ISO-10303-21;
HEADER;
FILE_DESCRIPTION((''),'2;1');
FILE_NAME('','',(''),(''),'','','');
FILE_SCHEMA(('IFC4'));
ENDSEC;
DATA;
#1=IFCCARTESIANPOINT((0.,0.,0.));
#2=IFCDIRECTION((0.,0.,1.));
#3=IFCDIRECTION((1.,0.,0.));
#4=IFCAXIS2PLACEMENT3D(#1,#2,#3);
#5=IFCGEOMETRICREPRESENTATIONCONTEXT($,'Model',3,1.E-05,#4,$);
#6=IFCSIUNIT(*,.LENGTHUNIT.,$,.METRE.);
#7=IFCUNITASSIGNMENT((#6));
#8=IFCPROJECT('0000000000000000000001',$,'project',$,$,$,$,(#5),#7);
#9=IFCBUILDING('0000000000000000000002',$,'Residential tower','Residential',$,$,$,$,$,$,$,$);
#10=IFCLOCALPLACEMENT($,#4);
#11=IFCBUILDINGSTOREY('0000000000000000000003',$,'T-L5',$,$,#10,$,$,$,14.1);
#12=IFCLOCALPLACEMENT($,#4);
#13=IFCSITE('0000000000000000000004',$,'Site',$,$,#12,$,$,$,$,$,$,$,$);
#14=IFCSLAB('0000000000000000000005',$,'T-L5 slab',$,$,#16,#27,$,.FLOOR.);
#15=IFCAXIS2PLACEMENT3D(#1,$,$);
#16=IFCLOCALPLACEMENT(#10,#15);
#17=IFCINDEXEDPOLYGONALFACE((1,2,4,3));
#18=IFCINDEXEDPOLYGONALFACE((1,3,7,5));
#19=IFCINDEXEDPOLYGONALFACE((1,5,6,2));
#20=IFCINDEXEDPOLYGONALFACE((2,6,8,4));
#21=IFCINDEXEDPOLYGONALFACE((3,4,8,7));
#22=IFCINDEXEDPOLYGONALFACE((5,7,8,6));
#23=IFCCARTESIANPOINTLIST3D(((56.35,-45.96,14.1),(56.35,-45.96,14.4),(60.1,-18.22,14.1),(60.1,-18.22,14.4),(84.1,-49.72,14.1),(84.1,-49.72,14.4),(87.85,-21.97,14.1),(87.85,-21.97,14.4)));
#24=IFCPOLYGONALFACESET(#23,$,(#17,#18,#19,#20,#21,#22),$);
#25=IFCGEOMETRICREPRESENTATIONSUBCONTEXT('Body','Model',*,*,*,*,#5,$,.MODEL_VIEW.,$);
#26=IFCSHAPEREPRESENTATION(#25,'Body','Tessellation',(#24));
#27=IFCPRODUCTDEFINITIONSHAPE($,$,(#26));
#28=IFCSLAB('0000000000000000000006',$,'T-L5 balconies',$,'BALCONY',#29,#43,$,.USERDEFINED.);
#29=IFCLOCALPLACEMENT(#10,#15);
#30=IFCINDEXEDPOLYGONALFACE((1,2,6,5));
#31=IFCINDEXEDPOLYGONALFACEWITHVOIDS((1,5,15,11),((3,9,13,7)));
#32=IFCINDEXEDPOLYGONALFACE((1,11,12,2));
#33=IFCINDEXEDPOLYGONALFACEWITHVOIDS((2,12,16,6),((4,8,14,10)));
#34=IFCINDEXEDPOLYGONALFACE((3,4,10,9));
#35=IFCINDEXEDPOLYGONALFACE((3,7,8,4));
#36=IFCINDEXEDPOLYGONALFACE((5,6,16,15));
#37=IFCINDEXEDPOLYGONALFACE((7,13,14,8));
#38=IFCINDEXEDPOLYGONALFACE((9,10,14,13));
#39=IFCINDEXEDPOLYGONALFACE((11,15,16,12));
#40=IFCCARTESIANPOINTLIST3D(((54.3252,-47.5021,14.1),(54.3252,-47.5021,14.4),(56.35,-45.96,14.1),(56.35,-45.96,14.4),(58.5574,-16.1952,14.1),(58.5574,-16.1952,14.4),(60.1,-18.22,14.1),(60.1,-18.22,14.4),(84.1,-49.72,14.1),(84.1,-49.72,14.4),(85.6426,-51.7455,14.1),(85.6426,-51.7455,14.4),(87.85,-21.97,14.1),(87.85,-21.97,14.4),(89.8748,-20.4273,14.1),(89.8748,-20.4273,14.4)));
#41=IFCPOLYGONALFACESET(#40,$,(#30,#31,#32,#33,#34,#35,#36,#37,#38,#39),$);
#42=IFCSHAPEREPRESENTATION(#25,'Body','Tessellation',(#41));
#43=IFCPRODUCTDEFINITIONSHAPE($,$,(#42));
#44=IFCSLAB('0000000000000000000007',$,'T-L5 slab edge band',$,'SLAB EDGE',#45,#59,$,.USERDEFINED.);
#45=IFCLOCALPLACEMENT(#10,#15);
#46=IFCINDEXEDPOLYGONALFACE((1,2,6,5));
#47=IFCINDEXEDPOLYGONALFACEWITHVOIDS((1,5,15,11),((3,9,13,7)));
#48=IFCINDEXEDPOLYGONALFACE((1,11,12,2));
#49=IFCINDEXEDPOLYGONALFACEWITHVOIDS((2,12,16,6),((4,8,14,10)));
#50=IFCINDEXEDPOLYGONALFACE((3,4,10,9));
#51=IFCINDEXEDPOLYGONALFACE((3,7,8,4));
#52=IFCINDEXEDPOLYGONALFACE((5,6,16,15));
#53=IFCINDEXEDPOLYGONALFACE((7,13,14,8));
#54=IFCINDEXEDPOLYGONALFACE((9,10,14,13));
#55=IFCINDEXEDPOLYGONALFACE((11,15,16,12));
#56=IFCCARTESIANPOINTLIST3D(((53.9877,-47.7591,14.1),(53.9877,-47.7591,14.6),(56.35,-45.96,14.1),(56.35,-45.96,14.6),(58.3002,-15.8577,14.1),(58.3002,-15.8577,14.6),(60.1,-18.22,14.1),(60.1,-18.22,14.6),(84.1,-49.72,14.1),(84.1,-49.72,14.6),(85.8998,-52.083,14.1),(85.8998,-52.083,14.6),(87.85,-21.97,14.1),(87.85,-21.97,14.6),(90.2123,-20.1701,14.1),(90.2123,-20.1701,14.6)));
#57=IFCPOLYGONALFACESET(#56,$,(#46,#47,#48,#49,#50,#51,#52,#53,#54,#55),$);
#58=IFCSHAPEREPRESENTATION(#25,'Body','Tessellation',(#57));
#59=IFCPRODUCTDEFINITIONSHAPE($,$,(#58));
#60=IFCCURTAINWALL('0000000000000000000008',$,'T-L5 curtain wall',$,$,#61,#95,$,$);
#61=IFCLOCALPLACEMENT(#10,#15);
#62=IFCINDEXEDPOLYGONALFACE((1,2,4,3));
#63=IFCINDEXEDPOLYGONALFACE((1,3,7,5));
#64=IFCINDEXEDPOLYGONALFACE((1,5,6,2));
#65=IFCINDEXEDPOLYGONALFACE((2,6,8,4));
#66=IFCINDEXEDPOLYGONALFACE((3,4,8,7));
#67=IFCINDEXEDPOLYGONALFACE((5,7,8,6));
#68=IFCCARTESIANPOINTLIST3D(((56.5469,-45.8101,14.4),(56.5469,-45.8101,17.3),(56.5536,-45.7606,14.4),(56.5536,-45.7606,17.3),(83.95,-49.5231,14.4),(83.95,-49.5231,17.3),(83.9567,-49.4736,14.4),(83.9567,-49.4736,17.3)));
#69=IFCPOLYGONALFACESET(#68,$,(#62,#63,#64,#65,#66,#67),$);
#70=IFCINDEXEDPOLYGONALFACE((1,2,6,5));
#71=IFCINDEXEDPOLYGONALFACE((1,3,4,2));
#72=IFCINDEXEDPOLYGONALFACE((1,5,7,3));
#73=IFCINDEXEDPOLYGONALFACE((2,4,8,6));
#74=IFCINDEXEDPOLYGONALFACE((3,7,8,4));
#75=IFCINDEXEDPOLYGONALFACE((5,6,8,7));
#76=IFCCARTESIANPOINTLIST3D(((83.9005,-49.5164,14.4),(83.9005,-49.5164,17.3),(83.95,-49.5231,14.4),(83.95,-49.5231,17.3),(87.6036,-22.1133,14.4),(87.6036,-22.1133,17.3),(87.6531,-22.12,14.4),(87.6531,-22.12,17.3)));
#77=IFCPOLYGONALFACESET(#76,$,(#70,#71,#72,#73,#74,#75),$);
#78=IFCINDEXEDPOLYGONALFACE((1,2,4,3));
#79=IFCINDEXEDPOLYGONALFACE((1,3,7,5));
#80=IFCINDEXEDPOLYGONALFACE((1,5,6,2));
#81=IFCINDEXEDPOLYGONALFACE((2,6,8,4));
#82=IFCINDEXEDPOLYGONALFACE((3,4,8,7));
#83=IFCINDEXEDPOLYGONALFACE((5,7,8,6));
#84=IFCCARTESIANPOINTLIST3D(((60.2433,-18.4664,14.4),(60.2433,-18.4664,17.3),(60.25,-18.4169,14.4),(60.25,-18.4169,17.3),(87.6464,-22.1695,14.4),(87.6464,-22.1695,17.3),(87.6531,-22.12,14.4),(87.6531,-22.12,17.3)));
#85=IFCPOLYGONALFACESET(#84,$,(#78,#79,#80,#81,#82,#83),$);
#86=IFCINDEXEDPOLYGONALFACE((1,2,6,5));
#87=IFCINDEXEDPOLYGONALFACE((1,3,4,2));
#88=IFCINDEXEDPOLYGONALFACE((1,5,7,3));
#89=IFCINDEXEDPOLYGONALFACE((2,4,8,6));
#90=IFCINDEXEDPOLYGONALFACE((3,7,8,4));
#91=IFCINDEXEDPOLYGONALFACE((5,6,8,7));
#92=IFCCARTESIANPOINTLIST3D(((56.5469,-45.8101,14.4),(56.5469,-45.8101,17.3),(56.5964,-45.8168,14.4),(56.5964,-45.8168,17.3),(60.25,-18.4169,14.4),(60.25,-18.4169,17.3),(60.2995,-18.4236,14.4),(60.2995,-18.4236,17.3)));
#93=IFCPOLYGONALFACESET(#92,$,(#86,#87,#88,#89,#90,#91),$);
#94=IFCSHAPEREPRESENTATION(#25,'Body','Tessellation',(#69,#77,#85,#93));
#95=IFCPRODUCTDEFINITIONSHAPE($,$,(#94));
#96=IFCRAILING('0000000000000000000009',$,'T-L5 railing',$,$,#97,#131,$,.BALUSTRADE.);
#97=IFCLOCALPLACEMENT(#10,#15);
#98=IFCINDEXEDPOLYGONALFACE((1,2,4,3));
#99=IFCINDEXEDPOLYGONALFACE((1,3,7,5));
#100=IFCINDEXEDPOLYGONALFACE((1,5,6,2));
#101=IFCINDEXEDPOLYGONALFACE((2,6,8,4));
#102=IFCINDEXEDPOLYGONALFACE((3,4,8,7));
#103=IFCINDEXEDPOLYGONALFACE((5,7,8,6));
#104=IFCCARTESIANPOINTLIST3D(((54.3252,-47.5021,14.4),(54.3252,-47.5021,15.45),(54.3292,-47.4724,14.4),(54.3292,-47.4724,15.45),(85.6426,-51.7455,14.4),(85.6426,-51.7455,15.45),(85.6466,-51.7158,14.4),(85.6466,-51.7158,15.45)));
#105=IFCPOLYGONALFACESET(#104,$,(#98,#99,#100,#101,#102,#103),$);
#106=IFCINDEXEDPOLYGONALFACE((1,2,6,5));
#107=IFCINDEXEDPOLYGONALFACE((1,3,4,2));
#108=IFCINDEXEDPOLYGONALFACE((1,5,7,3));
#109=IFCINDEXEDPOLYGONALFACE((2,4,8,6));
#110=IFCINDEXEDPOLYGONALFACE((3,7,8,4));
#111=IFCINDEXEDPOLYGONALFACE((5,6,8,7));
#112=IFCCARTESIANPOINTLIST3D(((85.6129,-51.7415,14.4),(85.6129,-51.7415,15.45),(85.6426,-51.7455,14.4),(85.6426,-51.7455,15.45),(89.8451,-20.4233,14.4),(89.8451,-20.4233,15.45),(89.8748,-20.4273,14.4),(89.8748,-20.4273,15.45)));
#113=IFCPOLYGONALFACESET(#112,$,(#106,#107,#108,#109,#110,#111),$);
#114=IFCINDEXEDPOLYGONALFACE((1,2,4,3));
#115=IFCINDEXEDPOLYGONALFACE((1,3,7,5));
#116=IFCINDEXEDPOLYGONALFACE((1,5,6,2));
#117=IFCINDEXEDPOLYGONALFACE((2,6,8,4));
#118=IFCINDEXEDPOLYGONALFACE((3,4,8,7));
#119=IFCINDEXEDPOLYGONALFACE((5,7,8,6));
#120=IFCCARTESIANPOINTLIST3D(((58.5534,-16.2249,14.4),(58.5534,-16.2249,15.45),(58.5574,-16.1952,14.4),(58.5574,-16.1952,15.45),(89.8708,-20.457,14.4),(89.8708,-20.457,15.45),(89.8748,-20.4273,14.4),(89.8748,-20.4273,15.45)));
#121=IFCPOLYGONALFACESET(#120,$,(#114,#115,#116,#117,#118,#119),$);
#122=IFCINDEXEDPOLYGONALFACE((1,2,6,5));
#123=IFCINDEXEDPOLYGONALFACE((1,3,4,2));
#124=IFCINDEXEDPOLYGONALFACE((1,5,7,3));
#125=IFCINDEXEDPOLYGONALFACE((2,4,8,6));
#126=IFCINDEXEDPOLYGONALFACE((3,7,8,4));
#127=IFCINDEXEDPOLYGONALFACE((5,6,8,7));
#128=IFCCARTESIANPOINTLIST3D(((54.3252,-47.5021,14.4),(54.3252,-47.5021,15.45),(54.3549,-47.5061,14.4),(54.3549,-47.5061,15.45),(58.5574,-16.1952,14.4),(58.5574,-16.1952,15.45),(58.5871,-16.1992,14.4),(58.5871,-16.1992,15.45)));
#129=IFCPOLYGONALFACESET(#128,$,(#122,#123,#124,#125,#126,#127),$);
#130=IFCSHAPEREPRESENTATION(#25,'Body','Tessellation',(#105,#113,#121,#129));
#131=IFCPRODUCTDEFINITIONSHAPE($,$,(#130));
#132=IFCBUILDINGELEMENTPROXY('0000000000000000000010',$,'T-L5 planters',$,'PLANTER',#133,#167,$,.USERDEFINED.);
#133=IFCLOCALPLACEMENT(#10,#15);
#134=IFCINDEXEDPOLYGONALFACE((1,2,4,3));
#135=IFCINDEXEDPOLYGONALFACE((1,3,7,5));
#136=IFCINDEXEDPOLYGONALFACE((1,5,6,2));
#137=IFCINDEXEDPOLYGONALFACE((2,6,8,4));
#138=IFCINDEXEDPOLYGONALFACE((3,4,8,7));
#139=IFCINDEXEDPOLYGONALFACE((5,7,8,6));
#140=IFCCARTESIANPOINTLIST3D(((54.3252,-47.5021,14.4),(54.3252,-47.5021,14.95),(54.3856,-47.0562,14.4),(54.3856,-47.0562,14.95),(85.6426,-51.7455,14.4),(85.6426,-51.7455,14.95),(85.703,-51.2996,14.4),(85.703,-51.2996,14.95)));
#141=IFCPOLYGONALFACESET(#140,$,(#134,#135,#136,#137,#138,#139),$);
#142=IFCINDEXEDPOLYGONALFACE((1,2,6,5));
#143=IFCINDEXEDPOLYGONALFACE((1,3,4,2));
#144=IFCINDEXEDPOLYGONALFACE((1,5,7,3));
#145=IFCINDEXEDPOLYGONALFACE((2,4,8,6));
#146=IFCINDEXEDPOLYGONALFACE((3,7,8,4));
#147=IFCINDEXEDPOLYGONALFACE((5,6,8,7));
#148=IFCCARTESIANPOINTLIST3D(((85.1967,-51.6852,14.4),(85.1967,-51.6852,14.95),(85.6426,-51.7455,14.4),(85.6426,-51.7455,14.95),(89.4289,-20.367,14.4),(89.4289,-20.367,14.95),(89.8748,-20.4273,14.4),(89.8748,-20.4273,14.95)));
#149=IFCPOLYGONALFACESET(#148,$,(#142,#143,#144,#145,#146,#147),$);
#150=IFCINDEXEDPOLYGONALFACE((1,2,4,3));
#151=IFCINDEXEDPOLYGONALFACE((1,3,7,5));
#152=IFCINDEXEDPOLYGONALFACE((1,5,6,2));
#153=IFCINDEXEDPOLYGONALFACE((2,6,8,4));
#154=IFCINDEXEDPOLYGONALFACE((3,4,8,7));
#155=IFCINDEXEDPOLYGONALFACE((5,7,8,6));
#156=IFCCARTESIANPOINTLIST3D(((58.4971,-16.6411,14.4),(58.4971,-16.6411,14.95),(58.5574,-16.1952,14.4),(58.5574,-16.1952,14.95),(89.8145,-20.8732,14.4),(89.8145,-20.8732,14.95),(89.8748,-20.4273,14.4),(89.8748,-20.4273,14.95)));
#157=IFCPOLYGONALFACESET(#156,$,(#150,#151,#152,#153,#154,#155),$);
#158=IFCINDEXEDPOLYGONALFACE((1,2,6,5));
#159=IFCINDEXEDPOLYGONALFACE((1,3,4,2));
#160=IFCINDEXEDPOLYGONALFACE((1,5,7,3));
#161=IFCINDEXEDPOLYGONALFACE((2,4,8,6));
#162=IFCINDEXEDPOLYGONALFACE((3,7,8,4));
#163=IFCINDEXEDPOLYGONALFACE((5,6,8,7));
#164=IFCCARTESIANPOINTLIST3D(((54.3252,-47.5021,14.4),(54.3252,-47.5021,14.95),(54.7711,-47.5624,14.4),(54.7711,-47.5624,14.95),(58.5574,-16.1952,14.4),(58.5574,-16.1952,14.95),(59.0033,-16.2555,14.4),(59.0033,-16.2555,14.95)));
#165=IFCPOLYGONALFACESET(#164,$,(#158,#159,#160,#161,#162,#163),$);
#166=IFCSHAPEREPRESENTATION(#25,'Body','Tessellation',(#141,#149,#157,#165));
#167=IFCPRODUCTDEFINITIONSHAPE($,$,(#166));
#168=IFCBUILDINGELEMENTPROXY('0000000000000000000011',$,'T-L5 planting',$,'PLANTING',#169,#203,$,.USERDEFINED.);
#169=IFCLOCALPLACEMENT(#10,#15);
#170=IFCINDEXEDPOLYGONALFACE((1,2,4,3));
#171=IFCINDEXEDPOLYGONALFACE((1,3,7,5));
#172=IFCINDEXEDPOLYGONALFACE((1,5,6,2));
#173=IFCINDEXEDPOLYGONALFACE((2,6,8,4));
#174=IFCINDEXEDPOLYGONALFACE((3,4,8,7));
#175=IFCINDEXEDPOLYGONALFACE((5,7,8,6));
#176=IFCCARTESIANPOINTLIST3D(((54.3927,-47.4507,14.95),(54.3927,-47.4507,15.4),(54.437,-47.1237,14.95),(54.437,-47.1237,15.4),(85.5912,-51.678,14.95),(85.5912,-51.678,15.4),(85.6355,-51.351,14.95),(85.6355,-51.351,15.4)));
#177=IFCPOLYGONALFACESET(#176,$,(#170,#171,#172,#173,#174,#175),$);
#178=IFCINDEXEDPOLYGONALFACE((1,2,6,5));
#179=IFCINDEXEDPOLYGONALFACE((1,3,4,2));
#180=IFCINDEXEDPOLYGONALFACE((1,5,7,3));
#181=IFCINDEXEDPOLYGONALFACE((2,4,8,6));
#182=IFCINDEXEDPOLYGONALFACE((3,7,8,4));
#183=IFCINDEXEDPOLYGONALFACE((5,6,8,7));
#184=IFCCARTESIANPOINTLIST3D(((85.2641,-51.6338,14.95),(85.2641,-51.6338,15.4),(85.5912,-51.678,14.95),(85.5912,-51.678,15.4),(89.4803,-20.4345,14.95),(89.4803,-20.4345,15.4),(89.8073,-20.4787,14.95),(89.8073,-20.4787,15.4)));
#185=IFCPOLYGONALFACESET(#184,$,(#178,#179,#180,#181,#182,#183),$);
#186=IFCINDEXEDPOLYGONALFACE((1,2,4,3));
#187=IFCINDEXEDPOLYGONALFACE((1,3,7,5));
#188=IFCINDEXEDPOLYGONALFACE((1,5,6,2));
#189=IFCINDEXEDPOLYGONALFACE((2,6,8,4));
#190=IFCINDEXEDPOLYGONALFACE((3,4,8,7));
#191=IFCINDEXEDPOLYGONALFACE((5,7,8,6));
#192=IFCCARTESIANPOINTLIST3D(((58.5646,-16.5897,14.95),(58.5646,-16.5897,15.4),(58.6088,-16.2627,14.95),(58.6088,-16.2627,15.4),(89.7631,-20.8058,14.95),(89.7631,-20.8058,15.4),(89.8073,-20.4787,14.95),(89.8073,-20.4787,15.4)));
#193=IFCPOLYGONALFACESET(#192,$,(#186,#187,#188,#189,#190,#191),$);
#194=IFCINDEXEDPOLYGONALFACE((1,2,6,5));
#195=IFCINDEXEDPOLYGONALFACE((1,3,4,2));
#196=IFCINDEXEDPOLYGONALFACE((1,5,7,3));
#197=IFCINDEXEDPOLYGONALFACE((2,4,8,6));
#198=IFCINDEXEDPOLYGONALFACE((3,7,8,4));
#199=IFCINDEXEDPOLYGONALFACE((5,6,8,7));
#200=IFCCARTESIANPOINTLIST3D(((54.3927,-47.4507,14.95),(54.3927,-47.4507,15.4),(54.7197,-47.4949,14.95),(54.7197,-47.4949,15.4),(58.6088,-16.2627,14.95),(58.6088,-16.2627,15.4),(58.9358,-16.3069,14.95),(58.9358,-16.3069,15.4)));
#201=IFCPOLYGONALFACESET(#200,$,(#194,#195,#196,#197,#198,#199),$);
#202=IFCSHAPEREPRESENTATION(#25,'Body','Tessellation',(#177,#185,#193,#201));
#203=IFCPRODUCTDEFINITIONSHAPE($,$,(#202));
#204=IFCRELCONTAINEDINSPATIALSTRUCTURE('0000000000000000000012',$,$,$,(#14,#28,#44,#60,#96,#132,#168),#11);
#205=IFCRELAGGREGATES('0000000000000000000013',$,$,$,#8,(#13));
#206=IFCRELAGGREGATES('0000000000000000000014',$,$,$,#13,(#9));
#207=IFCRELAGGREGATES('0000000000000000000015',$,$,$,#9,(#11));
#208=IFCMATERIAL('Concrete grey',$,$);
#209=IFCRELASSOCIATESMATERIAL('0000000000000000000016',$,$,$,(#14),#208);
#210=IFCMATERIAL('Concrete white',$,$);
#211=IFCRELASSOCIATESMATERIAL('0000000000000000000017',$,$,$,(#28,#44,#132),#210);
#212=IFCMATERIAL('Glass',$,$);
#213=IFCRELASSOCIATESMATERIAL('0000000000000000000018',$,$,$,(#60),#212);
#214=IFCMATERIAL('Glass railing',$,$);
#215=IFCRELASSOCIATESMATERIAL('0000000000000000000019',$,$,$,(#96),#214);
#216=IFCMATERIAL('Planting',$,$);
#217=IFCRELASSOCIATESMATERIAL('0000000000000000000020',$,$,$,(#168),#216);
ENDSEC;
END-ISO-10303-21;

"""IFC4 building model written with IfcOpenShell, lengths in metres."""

from ifc_helpers import new_model, si_unit, frame, origin_with_axes, place, context, subcontext, project, spatial, polyline, outline, extrude, material, element, save


model = new_model("IFC4")

# Units and contexts
model_context = context("Model", 3, precision=1e-05, world=origin_with_axes())
body_context = subcontext(model_context, "Body", "Model", "MODEL_VIEW")
ifc_project = project(units=[si_unit("LENGTHUNIT", "METRE")], contexts=[model_context])

# Site, building, storey
site_placement = place(None, origin_with_axes())
site = spatial("IfcSite", under=ifc_project, at=site_placement, Name="Site")
building = spatial("IfcBuilding", under=site, Name="Residential tower", Description="Residential")
storey_placement = place(None, origin_with_axes())
storey = spatial("IfcBuildingStorey", under=building, at=storey_placement, Name="T-L5", Elevation=14.1)

# Slabs
ifc_material_1 = material(Name="Concrete grey")
slab_1_placement = place(storey_placement, origin_with_axes())
element("IfcSlab", 1, at=slab_1_placement, inside=storey, material=ifc_material_1, Name="T-L5 slab", PredefinedType="FLOOR", context=body_context, shape_type="SweptSolid", body=[
    extrude(outline(polyline([(56.35, -45.96), (84.1, -49.72), (87.85, -21.97), (60.1, -18.22), (56.35, -45.96)])), frame((0.0, 0.0, 14.1), z_axis=(0.0, 0.0, 1.0), x_axis=(1.0, 0.0, 0.0)), (0.0, 0.0, 1.0), 0.3),
])
ifc_material_2 = material(Name="Concrete white")
slab_2_placement = place(storey_placement, origin_with_axes())
element("IfcSlab", 2, at=slab_2_placement, inside=storey, material=ifc_material_2, Name="T-L5 balconies", ObjectType="BALCONY", PredefinedType="USERDEFINED", context=body_context, shape_type="SweptSolid", body=[
    extrude(outline(polyline([(54.3252, -47.5021), (85.6426, -51.7455), (89.8748, -20.4273), (58.5574, -16.1952), (54.3252, -47.5021)]), holes=[polyline([(56.35, -45.96), (84.1, -49.72), (87.85, -21.97), (60.1, -18.22), (56.35, -45.96)])]), frame((0.0, 0.0, 14.1), z_axis=(0.0, 0.0, 1.0), x_axis=(1.0, 0.0, 0.0)), (0.0, 0.0, 1.0), 0.3),
])
slab_3_placement = place(storey_placement, origin_with_axes())
element("IfcSlab", 3, at=slab_3_placement, inside=storey, material=ifc_material_2, Name="T-L5 slab edge band", ObjectType="SLAB EDGE", PredefinedType="USERDEFINED", context=body_context, shape_type="SweptSolid", body=[
    extrude(outline(polyline([(53.9877, -47.7591), (85.8998, -52.083), (90.2123, -20.1701), (58.3002, -15.8577), (53.9877, -47.7591)]), holes=[polyline([(56.35, -45.96), (84.1, -49.72), (87.85, -21.97), (60.1, -18.22), (56.35, -45.96)])]), frame((0.0, 0.0, 14.1), z_axis=(0.0, 0.0, 1.0), x_axis=(1.0, 0.0, 0.0)), (0.0, 0.0, 1.0), 0.5),
])

# Curtain wall
ifc_material_3 = material(Name="Glass")
curtain_wall_placement = place(storey_placement, origin_with_axes())
element("IfcCurtainWall", 4, at=curtain_wall_placement, inside=storey, material=ifc_material_3, Name="T-L5 curtain wall", context=body_context, shape_type="SweptSolid", body=[
    extrude(outline(polyline([(56.5469, -45.8101), (83.95, -49.5231), (83.9567, -49.4736), (56.5536, -45.7606), (56.5469, -45.8101)])), frame((0.0, 0.0, 14.4), z_axis=(0.0, 0.0, 1.0), x_axis=(1.0, 0.0, 0.0)), (0.0, 0.0, 1.0), 2.9),
    extrude(outline(polyline([(83.95, -49.5231), (87.6531, -22.12), (87.6036, -22.1133), (83.9005, -49.5164), (83.95, -49.5231)])), frame((0.0, 0.0, 14.4), z_axis=(0.0, 0.0, 1.0), x_axis=(1.0, 0.0, 0.0)), (0.0, 0.0, 1.0), 2.9),
    extrude(outline(polyline([(87.6531, -22.12), (60.25, -18.4169), (60.2433, -18.4664), (87.6464, -22.1695), (87.6531, -22.12)])), frame((0.0, 0.0, 14.4), z_axis=(0.0, 0.0, 1.0), x_axis=(1.0, 0.0, 0.0)), (0.0, 0.0, 1.0), 2.9),
    extrude(outline(polyline([(60.25, -18.4169), (56.5469, -45.8101), (56.5964, -45.8168), (60.2995, -18.4236), (60.25, -18.4169)])), frame((0.0, 0.0, 14.4), z_axis=(0.0, 0.0, 1.0), x_axis=(1.0, 0.0, 0.0)), (0.0, 0.0, 1.0), 2.9),
])

# Railing
ifc_material_4 = material(Name="Glass railing")
railing_placement = place(storey_placement, origin_with_axes())
element("IfcRailing", 5, at=railing_placement, inside=storey, material=ifc_material_4, Name="T-L5 railing", PredefinedType="BALUSTRADE", context=body_context, shape_type="SweptSolid", body=[
    extrude(outline(polyline([(54.3252, -47.5021), (85.6426, -51.7455), (85.6466, -51.7158), (54.3292, -47.4724), (54.3252, -47.5021)])), frame((0.0, 0.0, 14.4), z_axis=(0.0, 0.0, 1.0), x_axis=(1.0, 0.0, 0.0)), (0.0, 0.0, 1.0), 1.05),
    extrude(outline(polyline([(85.6426, -51.7455), (89.8748, -20.4273), (89.8451, -20.4233), (85.6129, -51.7415), (85.6426, -51.7455)])), frame((0.0, 0.0, 14.4), z_axis=(0.0, 0.0, 1.0), x_axis=(1.0, 0.0, 0.0)), (0.0, 0.0, 1.0), 1.05),
    extrude(outline(polyline([(89.8748, -20.4273), (58.5574, -16.1952), (58.5534, -16.2249), (89.8708, -20.457), (89.8748, -20.4273)])), frame((0.0, 0.0, 14.4), z_axis=(0.0, 0.0, 1.0), x_axis=(1.0, 0.0, 0.0)), (0.0, 0.0, 1.0), 1.05),
    extrude(outline(polyline([(58.5574, -16.1952), (54.3252, -47.5021), (54.3549, -47.5061), (58.5871, -16.1992), (58.5574, -16.1952)])), frame((0.0, 0.0, 14.4), z_axis=(0.0, 0.0, 1.0), x_axis=(1.0, 0.0, 0.0)), (0.0, 0.0, 1.0), 1.05),
])

# Building element proxies
proxy_1_placement = place(storey_placement, origin_with_axes())
element("IfcBuildingElementProxy", 6, at=proxy_1_placement, inside=storey, material=ifc_material_2, Name="T-L5 planters", ObjectType="PLANTER", PredefinedType="USERDEFINED", context=body_context, shape_type="SweptSolid", body=[
    extrude(outline(polyline([(54.3252, -47.5021), (85.6426, -51.7455), (85.703, -51.2996), (54.3856, -47.0562), (54.3252, -47.5021)])), frame((0.0, 0.0, 14.4), z_axis=(0.0, 0.0, 1.0), x_axis=(1.0, 0.0, 0.0)), (0.0, 0.0, 1.0), 0.55),
    extrude(outline(polyline([(85.6426, -51.7455), (89.8748, -20.4273), (89.4289, -20.367), (85.1967, -51.6852), (85.6426, -51.7455)])), frame((0.0, 0.0, 14.4), z_axis=(0.0, 0.0, 1.0), x_axis=(1.0, 0.0, 0.0)), (0.0, 0.0, 1.0), 0.55),
    extrude(outline(polyline([(89.8748, -20.4273), (58.5574, -16.1952), (58.4971, -16.6411), (89.8145, -20.8732), (89.8748, -20.4273)])), frame((0.0, 0.0, 14.4), z_axis=(0.0, 0.0, 1.0), x_axis=(1.0, 0.0, 0.0)), (0.0, 0.0, 1.0), 0.55),
    extrude(outline(polyline([(58.5574, -16.1952), (54.3252, -47.5021), (54.7711, -47.5624), (59.0033, -16.2555), (58.5574, -16.1952)])), frame((0.0, 0.0, 14.4), z_axis=(0.0, 0.0, 1.0), x_axis=(1.0, 0.0, 0.0)), (0.0, 0.0, 1.0), 0.55),
])
ifc_material_5 = material(Name="Planting")
proxy_2_placement = place(storey_placement, origin_with_axes())
element("IfcBuildingElementProxy", 7, at=proxy_2_placement, inside=storey, material=ifc_material_5, Name="T-L5 planting", ObjectType="PLANTING", PredefinedType="USERDEFINED", context=body_context, shape_type="SweptSolid", body=[
    extrude(outline(polyline([(54.3927, -47.4507), (85.5912, -51.678), (85.6355, -51.351), (54.437, -47.1237), (54.3927, -47.4507)])), frame((0.0, 0.0, 14.95), z_axis=(0.0, 0.0, 1.0), x_axis=(1.0, 0.0, 0.0)), (0.0, 0.0, 1.0), 0.45),
    extrude(outline(polyline([(85.5912, -51.678), (89.8073, -20.4787), (89.4803, -20.4345), (85.2641, -51.6338), (85.5912, -51.678)])), frame((0.0, 0.0, 14.95), z_axis=(0.0, 0.0, 1.0), x_axis=(1.0, 0.0, 0.0)), (0.0, 0.0, 1.0), 0.45),
    extrude(outline(polyline([(89.8073, -20.4787), (58.6088, -16.2627), (58.5646, -16.5897), (89.7631, -20.8058), (89.8073, -20.4787)])), frame((0.0, 0.0, 14.95), z_axis=(0.0, 0.0, 1.0), x_axis=(1.0, 0.0, 0.0)), (0.0, 0.0, 1.0), 0.45),
    extrude(outline(polyline([(58.6088, -16.2627), (54.3927, -47.4507), (54.7197, -47.4949), (58.9358, -16.3069), (58.6088, -16.2627)])), frame((0.0, 0.0, 14.95), z_axis=(0.0, 0.0, 1.0), x_axis=(1.0, 0.0, 0.0)), (0.0, 0.0, 1.0), 0.45),
])

save(model, "model.ifc")
